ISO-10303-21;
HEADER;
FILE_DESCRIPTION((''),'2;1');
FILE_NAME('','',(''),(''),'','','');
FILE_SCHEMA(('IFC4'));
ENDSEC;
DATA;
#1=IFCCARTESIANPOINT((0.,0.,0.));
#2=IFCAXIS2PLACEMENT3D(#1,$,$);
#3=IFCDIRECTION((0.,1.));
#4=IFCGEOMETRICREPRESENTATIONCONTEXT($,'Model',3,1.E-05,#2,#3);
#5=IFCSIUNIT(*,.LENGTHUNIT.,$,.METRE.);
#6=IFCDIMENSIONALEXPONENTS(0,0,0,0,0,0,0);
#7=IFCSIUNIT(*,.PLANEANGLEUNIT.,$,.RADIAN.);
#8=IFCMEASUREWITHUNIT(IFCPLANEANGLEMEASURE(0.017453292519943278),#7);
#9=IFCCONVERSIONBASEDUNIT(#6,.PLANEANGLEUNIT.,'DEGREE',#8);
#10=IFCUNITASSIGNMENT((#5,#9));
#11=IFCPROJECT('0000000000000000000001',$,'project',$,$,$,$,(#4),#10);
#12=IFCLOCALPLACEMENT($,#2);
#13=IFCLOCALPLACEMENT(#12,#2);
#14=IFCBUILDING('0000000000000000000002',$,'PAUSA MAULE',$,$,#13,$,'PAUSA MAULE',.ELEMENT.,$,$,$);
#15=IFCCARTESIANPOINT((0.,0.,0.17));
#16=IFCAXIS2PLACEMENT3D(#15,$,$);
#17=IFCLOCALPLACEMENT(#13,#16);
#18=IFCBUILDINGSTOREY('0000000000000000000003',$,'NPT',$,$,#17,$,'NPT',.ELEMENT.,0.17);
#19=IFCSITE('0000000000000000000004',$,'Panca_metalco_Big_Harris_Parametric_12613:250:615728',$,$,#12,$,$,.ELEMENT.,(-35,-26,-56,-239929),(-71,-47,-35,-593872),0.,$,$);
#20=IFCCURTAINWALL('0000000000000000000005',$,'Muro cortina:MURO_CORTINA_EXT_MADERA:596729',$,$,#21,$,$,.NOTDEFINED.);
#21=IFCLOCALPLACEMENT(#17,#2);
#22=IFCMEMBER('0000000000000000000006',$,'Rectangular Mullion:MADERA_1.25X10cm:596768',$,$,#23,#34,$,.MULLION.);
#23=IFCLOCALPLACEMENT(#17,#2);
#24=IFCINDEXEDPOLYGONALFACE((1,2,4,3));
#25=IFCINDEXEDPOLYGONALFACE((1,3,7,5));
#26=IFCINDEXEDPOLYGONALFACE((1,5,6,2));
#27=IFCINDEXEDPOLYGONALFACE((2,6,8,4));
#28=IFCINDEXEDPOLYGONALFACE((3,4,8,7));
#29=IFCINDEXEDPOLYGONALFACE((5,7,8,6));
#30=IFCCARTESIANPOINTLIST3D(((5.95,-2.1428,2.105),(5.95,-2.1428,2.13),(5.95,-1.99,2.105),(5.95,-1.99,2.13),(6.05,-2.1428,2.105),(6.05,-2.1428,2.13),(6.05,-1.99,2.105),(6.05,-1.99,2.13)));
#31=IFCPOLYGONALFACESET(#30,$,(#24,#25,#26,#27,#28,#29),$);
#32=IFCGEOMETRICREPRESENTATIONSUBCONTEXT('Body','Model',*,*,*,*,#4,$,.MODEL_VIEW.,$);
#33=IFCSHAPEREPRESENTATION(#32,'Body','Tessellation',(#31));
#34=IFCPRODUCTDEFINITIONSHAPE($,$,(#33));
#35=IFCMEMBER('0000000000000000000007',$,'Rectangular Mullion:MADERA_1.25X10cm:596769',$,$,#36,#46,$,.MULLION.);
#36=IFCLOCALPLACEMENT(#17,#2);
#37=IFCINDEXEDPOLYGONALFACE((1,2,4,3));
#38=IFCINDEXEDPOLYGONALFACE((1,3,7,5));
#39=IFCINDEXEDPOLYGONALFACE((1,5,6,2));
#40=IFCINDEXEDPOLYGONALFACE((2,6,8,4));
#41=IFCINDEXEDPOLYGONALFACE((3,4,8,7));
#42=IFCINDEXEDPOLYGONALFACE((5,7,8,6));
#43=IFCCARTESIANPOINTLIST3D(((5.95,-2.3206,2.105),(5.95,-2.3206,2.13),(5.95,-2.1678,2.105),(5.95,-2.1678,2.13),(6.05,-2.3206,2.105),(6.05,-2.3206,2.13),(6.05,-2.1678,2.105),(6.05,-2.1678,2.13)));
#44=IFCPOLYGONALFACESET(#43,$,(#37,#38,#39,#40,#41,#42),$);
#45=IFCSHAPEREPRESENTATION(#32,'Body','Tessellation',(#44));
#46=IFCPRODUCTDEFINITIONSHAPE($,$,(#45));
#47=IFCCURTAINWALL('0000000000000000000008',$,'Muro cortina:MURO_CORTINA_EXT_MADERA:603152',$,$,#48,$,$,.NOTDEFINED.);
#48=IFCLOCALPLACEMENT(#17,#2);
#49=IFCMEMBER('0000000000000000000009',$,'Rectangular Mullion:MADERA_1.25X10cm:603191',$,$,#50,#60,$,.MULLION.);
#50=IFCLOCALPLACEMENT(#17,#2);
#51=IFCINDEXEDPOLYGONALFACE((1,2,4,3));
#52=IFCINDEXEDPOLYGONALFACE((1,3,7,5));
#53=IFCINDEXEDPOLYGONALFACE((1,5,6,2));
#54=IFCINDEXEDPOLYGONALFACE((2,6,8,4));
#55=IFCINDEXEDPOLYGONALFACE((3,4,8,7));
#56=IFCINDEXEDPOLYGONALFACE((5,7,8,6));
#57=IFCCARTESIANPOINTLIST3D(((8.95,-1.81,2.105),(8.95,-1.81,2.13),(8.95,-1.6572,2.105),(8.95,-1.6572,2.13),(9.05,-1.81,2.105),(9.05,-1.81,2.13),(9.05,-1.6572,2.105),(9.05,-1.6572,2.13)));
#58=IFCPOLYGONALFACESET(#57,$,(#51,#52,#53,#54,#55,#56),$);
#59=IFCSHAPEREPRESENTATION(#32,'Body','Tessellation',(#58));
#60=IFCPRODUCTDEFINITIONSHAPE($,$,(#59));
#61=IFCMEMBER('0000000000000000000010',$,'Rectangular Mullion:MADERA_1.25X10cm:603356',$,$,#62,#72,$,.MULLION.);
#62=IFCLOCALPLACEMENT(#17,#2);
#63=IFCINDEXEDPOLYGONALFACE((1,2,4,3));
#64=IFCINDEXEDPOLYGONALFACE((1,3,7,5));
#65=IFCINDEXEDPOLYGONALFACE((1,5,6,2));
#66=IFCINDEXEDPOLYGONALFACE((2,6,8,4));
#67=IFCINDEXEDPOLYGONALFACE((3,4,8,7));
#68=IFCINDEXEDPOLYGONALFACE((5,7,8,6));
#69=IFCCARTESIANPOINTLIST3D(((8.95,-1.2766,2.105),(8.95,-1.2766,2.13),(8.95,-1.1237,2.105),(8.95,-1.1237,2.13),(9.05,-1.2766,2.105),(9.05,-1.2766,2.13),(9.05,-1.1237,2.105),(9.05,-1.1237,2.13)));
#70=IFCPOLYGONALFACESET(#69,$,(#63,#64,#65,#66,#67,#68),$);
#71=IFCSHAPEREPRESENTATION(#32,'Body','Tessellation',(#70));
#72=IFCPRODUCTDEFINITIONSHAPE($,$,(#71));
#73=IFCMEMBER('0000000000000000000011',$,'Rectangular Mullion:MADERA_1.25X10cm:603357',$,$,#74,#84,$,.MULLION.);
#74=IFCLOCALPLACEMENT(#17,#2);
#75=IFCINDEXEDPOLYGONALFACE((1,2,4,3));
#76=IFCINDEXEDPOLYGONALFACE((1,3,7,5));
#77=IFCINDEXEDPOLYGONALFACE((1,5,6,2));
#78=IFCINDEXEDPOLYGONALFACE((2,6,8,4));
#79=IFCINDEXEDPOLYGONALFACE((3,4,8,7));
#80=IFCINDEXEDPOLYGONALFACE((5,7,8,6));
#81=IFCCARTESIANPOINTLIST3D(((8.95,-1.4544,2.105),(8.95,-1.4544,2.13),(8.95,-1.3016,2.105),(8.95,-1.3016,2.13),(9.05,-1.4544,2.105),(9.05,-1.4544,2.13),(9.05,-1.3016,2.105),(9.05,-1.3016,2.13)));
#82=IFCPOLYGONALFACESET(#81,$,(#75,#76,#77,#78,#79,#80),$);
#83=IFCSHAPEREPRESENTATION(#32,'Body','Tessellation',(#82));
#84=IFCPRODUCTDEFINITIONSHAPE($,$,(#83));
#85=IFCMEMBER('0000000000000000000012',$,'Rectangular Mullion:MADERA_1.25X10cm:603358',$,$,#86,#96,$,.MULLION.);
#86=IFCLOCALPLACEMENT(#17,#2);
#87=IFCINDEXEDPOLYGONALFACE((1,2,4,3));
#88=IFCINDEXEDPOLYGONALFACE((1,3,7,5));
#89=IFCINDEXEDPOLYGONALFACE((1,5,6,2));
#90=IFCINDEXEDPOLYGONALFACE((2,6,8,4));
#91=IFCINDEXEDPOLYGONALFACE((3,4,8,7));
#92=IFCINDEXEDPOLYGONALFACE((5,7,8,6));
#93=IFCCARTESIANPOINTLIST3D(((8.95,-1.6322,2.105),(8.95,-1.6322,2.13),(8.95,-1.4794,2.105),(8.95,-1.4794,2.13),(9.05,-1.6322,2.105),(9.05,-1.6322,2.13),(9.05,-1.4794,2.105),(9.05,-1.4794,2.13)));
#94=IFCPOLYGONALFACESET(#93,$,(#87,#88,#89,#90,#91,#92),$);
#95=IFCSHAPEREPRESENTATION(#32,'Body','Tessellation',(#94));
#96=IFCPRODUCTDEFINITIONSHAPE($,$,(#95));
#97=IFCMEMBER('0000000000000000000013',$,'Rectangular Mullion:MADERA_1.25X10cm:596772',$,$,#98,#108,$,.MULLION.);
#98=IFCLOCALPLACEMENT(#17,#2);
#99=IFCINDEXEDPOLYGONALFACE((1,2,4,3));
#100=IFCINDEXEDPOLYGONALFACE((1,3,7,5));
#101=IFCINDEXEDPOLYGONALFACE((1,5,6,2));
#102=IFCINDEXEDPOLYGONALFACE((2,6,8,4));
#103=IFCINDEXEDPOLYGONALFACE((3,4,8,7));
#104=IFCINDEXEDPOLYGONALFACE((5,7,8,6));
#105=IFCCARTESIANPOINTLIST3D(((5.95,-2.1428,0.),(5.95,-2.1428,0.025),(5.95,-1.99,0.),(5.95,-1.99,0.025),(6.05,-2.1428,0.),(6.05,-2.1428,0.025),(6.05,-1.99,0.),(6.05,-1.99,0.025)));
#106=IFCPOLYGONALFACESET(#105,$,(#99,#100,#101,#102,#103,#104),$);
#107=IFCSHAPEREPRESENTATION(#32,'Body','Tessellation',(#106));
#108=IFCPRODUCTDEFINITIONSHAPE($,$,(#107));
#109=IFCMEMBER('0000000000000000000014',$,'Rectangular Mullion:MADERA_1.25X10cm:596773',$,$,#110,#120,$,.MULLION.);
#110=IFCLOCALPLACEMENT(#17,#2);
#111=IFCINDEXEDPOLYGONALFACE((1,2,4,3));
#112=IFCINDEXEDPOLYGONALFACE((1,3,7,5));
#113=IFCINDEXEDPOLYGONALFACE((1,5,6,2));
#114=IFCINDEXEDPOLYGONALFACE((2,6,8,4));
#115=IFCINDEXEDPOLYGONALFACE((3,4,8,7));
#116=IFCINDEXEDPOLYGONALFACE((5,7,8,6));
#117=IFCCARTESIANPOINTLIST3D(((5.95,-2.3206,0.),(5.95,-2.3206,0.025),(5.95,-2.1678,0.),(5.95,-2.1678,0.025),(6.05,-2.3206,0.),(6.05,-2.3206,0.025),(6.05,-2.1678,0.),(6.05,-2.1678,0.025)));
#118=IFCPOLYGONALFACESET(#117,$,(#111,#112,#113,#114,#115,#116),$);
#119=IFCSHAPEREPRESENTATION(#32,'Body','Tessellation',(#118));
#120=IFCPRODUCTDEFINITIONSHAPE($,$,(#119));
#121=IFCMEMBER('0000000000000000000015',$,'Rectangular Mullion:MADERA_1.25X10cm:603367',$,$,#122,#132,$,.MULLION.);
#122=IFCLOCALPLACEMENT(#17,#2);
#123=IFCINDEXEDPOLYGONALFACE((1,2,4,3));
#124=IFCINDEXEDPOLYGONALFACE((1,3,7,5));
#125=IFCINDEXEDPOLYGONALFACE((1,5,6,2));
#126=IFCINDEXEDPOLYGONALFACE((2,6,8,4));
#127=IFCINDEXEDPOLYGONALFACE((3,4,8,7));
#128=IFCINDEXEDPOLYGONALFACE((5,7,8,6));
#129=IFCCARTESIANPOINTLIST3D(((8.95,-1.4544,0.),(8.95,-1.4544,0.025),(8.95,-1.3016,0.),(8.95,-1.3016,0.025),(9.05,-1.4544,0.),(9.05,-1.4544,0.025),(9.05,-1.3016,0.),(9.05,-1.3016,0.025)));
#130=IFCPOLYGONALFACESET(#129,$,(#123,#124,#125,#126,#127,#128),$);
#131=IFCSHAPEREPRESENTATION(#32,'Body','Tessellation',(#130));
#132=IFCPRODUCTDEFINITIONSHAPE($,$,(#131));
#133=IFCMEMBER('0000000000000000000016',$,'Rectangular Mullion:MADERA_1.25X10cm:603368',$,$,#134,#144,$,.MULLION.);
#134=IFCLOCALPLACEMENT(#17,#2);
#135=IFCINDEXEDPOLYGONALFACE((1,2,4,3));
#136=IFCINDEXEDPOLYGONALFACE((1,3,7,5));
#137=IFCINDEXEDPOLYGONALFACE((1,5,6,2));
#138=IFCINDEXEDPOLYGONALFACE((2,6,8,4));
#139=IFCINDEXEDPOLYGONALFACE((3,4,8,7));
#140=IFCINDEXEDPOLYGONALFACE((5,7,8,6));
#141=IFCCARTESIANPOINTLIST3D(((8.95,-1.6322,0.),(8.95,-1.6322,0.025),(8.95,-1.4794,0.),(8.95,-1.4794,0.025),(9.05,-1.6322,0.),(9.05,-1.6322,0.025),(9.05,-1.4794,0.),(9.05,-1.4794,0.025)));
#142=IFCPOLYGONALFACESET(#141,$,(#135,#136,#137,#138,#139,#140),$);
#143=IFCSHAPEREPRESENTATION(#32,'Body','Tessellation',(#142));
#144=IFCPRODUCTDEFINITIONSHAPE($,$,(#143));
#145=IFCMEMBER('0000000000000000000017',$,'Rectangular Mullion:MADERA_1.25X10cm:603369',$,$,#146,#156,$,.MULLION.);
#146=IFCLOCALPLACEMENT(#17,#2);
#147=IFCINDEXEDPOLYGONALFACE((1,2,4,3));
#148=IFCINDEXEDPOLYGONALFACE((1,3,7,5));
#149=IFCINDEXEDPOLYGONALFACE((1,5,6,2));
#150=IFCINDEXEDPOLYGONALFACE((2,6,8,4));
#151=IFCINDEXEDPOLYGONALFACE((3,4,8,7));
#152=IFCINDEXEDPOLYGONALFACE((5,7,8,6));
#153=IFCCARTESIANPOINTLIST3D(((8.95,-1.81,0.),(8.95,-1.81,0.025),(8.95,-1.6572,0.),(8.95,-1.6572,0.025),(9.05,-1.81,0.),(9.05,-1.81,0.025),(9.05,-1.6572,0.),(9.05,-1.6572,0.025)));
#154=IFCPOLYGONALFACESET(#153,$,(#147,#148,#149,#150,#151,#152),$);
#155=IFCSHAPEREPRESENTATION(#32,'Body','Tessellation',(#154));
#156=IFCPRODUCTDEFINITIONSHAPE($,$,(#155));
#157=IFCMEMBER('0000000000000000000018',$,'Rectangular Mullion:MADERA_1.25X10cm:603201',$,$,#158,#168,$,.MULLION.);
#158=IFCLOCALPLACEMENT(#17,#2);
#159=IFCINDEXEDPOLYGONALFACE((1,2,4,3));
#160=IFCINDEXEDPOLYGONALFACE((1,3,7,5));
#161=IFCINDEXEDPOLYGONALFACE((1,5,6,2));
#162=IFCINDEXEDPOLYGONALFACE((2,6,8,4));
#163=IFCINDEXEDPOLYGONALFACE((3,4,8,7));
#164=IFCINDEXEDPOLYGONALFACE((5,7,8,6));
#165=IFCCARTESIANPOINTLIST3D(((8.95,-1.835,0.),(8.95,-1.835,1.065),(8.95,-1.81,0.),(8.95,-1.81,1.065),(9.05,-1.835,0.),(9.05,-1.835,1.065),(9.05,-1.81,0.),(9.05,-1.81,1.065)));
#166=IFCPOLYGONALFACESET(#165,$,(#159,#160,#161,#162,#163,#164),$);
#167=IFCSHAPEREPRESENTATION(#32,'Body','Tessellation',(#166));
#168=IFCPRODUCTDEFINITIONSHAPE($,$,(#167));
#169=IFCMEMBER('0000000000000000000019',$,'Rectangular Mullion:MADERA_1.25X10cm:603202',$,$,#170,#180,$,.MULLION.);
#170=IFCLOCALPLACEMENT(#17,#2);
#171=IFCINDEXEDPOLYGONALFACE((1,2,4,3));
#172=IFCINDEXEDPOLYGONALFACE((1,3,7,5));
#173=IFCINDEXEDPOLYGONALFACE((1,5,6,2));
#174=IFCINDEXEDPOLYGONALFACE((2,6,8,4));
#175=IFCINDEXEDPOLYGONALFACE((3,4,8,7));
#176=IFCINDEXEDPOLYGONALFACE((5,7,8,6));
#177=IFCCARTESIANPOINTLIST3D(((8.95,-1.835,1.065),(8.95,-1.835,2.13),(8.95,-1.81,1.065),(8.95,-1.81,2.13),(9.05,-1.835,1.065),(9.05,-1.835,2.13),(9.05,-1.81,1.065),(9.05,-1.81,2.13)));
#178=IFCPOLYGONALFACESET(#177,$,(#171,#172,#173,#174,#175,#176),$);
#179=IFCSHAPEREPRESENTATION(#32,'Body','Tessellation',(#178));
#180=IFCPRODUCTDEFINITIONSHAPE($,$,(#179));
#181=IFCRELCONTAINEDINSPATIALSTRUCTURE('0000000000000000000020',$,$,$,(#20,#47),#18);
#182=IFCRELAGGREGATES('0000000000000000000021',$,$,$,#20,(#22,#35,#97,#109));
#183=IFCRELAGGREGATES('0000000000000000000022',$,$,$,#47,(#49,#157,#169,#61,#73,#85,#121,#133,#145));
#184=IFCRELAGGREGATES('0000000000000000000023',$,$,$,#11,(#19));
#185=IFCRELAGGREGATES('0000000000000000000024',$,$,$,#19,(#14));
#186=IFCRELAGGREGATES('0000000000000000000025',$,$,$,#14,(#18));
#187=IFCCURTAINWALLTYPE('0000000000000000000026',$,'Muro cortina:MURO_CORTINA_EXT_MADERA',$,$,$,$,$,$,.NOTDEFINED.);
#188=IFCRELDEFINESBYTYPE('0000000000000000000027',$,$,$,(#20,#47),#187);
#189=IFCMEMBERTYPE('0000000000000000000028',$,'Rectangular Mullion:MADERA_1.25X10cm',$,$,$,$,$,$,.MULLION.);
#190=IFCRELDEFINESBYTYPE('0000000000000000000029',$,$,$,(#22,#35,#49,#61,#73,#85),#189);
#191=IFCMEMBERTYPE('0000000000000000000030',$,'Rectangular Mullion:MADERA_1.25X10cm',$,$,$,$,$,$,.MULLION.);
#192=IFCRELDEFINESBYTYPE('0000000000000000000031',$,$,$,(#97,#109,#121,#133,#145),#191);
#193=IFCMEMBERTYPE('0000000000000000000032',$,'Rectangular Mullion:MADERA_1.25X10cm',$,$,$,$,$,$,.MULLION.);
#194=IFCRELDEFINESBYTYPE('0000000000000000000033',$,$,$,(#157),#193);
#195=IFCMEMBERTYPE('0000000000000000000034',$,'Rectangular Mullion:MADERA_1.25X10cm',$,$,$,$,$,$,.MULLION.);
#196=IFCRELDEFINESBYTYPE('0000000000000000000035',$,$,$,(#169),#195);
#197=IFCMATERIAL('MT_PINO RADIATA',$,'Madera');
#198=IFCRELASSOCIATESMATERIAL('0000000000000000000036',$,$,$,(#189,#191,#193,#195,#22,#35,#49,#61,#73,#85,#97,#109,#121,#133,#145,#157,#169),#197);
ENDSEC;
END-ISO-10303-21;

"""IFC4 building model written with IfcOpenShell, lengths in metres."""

from ifc_helpers import new_model, entity, si_unit, converted_unit, direction, frame, frame_2d, origin, origin_2d_with_axis, place, context, subcontext, project, spatial, rectangle, extrude, source, transform, mapped, material, material_profile, profile_set, profile_usage, type_object, type_shapes, element, aggregate, save


model = new_model("IFC4")

# Units and contexts
model_context = context("Model", 3, precision=1e-05, world=origin(), true_north=direction((0.0, 1.0)))
body_context = subcontext(model_context, "Body", "Model", "MODEL_VIEW")
ifc_project = project(units=[si_unit("LENGTHUNIT", "METRE"), converted_unit("PLANEANGLEUNIT", "DEGREE", entity("IfcPlaneAngleMeasure", 0.017453292519943278), si_unit("PLANEANGLEUNIT", "RADIAN"), dimensions=[0, 0, 0, 0, 0, 0, 0])], contexts=[model_context])

# Site, building, storey
site_placement = place(None, origin())
site = spatial("IfcSite", under=ifc_project, at=site_placement, Name="Panca_metalco_Big_Harris_Parametric_12613:250:615728", CompositionType="ELEMENT", RefLatitude=(-35, -26, -56, -239929), RefLongitude=(-71, -47, -35, -593872), RefElevation=0.0)
building_placement = place(site_placement, origin())
building = spatial("IfcBuilding", under=site, at=building_placement, Name="PAUSA MAULE", LongName="PAUSA MAULE", CompositionType="ELEMENT")
storey_placement = place(building_placement, frame((0.0, 0.0, 0.17)))
storey = spatial("IfcBuildingStorey", under=building, at=storey_placement, Name="NPT", LongName="NPT", CompositionType="ELEMENT", Elevation=0.17)

# Curtain walls, members
curtain_wall_type = type_object("IfcCurtainWallType", Name="Muro cortina:MURO_CORTINA_EXT_MADERA", PredefinedType="NOTDEFINED")
curtain_wall_1_placement = place(storey_placement, frame((0.0, 0.0, -0.17)))
curtain_wall_1 = element("IfcCurtainWall", 1, at=curtain_wall_1_placement, inside=storey, type_object=curtain_wall_type, Name="Muro cortina:MURO_CORTINA_EXT_MADERA:596729", PredefinedType="NOTDEFINED")
ifc_material = material(Name="MT_PINO RADIATA", Category="Madera")
ifc_material_profile = material_profile(ifc_material, rectangle(XDim=0.025, YDim=0.1, at=frame_2d((0.0, 0.0), x_axis=(1.0, 0.0))), Name="MADERA_1.25X10cm")
ifc_profile_set = profile_set([ifc_material_profile], Name="MADERA_1.25X10cm")
ifc_profile_usage = profile_usage(ifc_profile_set)
member_type_1 = type_object("IfcMemberType", Name="Rectangular Mullion:MADERA_1.25X10cm", PredefinedType="MULLION", material=ifc_profile_set)
shared_shape_1 = source(origin(), body_context, "Body", "SweptSolid", [
    extrude(rectangle(XDim=0.025, YDim=0.1, at=frame_2d((0.0, 0.0), x_axis=(1.0, 0.0))), frame((-0.0125, 0.0, -0.1528), z_axis=(0.0, 0.0, 1.0), x_axis=(-1.0, 0.0, 0.0)), (0.0, 0.0, 1.0), 0.1528),
])
type_shapes(member_type_1, [shared_shape_1])
member_1_placement = place(curtain_wall_1_placement, frame((6.0, -2.1428, 2.3), z_axis=(0.0, -1.0, 0.0), x_axis=(0.0, 0.0, 1.0)))
member_1 = element("IfcMember", 2, at=member_1_placement, type_object=member_type_1, material=ifc_profile_usage, Name="Rectangular Mullion:MADERA_1.25X10cm:596768", PredefinedType="MULLION", context=body_context, shape_type="MappedRepresentation", body=[
    mapped(shared_shape_1, transform((0.0, 0.0, 0.0), scale=1.0)),
])
member_2_placement = place(curtain_wall_1_placement, frame((6.0, -2.3206, 2.3), z_axis=(0.0, -1.0, 0.0), x_axis=(0.0, 0.0, 1.0)))
member_2 = element("IfcMember", 3, at=member_2_placement, type_object=member_type_1, material=ifc_profile_usage, Name="Rectangular Mullion:MADERA_1.25X10cm:596769", PredefinedType="MULLION", context=body_context, shape_type="MappedRepresentation", body=[
    mapped(shared_shape_1, transform((0.0, 0.0, 0.0), scale=1.0)),
])
curtain_wall_2_placement = place(storey_placement, frame((0.0, 0.0, -0.17)))
curtain_wall_2 = element("IfcCurtainWall", 4, at=curtain_wall_2_placement, inside=storey, type_object=curtain_wall_type, Name="Muro cortina:MURO_CORTINA_EXT_MADERA:603152", PredefinedType="NOTDEFINED")
member_3_placement = place(curtain_wall_2_placement, frame((9.0, -1.81, 2.3), z_axis=(0.0, -1.0, 0.0), x_axis=(0.0, 0.0, 1.0)))
member_3 = element("IfcMember", 5, at=member_3_placement, type_object=member_type_1, material=ifc_profile_usage, Name="Rectangular Mullion:MADERA_1.25X10cm:603191", PredefinedType="MULLION", context=body_context, shape_type="MappedRepresentation", body=[
    mapped(shared_shape_1, transform((0.0, 0.0, 0.0), scale=1.0)),
])
member_4_placement = place(curtain_wall_2_placement, frame((9.0, -1.2766, 2.3), z_axis=(0.0, -1.0, 0.0), x_axis=(0.0, 0.0, 1.0)))
member_4 = element("IfcMember", 6, at=member_4_placement, type_object=member_type_1, material=ifc_profile_usage, Name="Rectangular Mullion:MADERA_1.25X10cm:603356", PredefinedType="MULLION", context=body_context, shape_type="MappedRepresentation", body=[
    mapped(shared_shape_1, transform((0.0, 0.0, 0.0), scale=1.0)),
])
member_5_placement = place(curtain_wall_2_placement, frame((9.0, -1.4544, 2.3), z_axis=(0.0, -1.0, 0.0), x_axis=(0.0, 0.0, 1.0)))
member_5 = element("IfcMember", 7, at=member_5_placement, type_object=member_type_1, material=ifc_profile_usage, Name="Rectangular Mullion:MADERA_1.25X10cm:603357", PredefinedType="MULLION", context=body_context, shape_type="MappedRepresentation", body=[
    mapped(shared_shape_1, transform((0.0, 0.0, 0.0), scale=1.0)),
])
member_6_placement = place(curtain_wall_2_placement, frame((9.0, -1.6322, 2.3), z_axis=(0.0, -1.0, 0.0), x_axis=(0.0, 0.0, 1.0)))
member_6 = element("IfcMember", 8, at=member_6_placement, type_object=member_type_1, material=ifc_profile_usage, Name="Rectangular Mullion:MADERA_1.25X10cm:603358", PredefinedType="MULLION", context=body_context, shape_type="MappedRepresentation", body=[
    mapped(shared_shape_1, transform((0.0, 0.0, 0.0), scale=1.0)),
])

# Members
member_type_2 = type_object("IfcMemberType", Name="Rectangular Mullion:MADERA_1.25X10cm", PredefinedType="MULLION", material=ifc_profile_set)
shared_shape_2 = source(origin(), body_context, "Body", "SweptSolid", [
    extrude(rectangle(XDim=0.025, YDim=0.1, at=frame_2d((0.0, 0.0), x_axis=(1.0, 0.0))), frame((-0.0125, 0.0, -0.1528), z_axis=(0.0, 0.0, 1.0), x_axis=(-1.0, 0.0, 0.0)), (0.0, 0.0, 1.0), 0.1528),
])
type_shapes(member_type_2, [shared_shape_2])
member_7_placement = place(curtain_wall_1_placement, frame((6.0, -1.99, 0.17), z_axis=(0.0, 1.0, 0.0), x_axis=(0.0, 0.0, -1.0)))
member_7 = element("IfcMember", 9, at=member_7_placement, type_object=member_type_2, material=ifc_profile_usage, Name="Rectangular Mullion:MADERA_1.25X10cm:596772", PredefinedType="MULLION", context=body_context, shape_type="MappedRepresentation", body=[
    mapped(shared_shape_2, transform((0.0, 0.0, 0.0), scale=1.0)),
])
member_8_placement = place(curtain_wall_1_placement, frame((6.0, -2.1678, 0.17), z_axis=(0.0, 1.0, 0.0), x_axis=(0.0, 0.0, -1.0)))
member_8 = element("IfcMember", 10, at=member_8_placement, type_object=member_type_2, material=ifc_profile_usage, Name="Rectangular Mullion:MADERA_1.25X10cm:596773", PredefinedType="MULLION", context=body_context, shape_type="MappedRepresentation", body=[
    mapped(shared_shape_2, transform((0.0, 0.0, 0.0), scale=1.0)),
])
member_9_placement = place(curtain_wall_2_placement, frame((9.0, -1.3016, 0.17), z_axis=(0.0, 1.0, 0.0), x_axis=(0.0, 0.0, -1.0)))
member_9 = element("IfcMember", 11, at=member_9_placement, type_object=member_type_2, material=ifc_profile_usage, Name="Rectangular Mullion:MADERA_1.25X10cm:603367", PredefinedType="MULLION", context=body_context, shape_type="MappedRepresentation", body=[
    mapped(shared_shape_2, transform((0.0, 0.0, 0.0), scale=1.0)),
])
member_10_placement = place(curtain_wall_2_placement, frame((9.0, -1.4794, 0.17), z_axis=(0.0, 1.0, 0.0), x_axis=(0.0, 0.0, -1.0)))
member_10 = element("IfcMember", 12, at=member_10_placement, type_object=member_type_2, material=ifc_profile_usage, Name="Rectangular Mullion:MADERA_1.25X10cm:603368", PredefinedType="MULLION", context=body_context, shape_type="MappedRepresentation", body=[
    mapped(shared_shape_2, transform((0.0, 0.0, 0.0), scale=1.0)),
])
member_11_placement = place(curtain_wall_2_placement, frame((9.0, -1.6572, 0.17), z_axis=(0.0, 1.0, 0.0), x_axis=(0.0, 0.0, -1.0)))
member_11 = element("IfcMember", 13, at=member_11_placement, type_object=member_type_2, material=ifc_profile_usage, Name="Rectangular Mullion:MADERA_1.25X10cm:603369", PredefinedType="MULLION", context=body_context, shape_type="MappedRepresentation", body=[
    mapped(shared_shape_2, transform((0.0, 0.0, 0.0), scale=1.0)),
])
member_type_3 = type_object("IfcMemberType", Name="Rectangular Mullion:MADERA_1.25X10cm", PredefinedType="MULLION", material=ifc_profile_set)
shared_shape_3 = source(origin(), body_context, "Body", "SweptSolid", [
    extrude(rectangle(XDim=0.025, YDim=0.1, at=origin_2d_with_axis()), frame((-0.0125, 0.0, -1.065), z_axis=(0.0, 0.0, 1.0), x_axis=(-1.0, 0.0, 0.0)), (0.0, 0.0, 1.0), 1.065),
])
type_shapes(member_type_3, [shared_shape_3])
member_12_placement = place(curtain_wall_2_placement, frame((9.0, -1.835, 0.17), z_axis=(0.0, 0.0, -1.0), x_axis=(0.0, -1.0, 0.0)))
member_12 = element("IfcMember", 14, at=member_12_placement, type_object=member_type_3, material=ifc_profile_usage, Name="Rectangular Mullion:MADERA_1.25X10cm:603201", PredefinedType="MULLION", context=body_context, shape_type="MappedRepresentation", body=[
    mapped(shared_shape_3, transform((0.0, 0.0, 0.0), scale=1.0)),
])
member_type_4 = type_object("IfcMemberType", Name="Rectangular Mullion:MADERA_1.25X10cm", PredefinedType="MULLION", material=ifc_profile_set)
shared_shape_4 = source(origin(), body_context, "Body", "SweptSolid", [
    extrude(rectangle(XDim=0.025, YDim=0.1, at=origin_2d_with_axis()), frame((-0.0125, 0.0, -1.065), z_axis=(0.0, 0.0, 1.0), x_axis=(-1.0, 0.0, 0.0)), (0.0, 0.0, 1.0), 1.065),
])
type_shapes(member_type_4, [shared_shape_4])
member_13_placement = place(curtain_wall_2_placement, frame((9.0, -1.835, 1.235), z_axis=(0.0, 0.0, -1.0), x_axis=(0.0, -1.0, 0.0)))
member_13 = element("IfcMember", 15, at=member_13_placement, type_object=member_type_4, material=ifc_profile_usage, Name="Rectangular Mullion:MADERA_1.25X10cm:603202", PredefinedType="MULLION", context=body_context, shape_type="MappedRepresentation", body=[
    mapped(shared_shape_4, transform((0.0, 0.0, 0.0), scale=1.0)),
])
aggregate(curtain_wall_1, [member_1, member_2, member_7, member_8])
aggregate(curtain_wall_2, [member_3, member_12, member_13, member_4, member_5, member_6, member_9, member_10, member_11])

save(model, "model.ifc")
